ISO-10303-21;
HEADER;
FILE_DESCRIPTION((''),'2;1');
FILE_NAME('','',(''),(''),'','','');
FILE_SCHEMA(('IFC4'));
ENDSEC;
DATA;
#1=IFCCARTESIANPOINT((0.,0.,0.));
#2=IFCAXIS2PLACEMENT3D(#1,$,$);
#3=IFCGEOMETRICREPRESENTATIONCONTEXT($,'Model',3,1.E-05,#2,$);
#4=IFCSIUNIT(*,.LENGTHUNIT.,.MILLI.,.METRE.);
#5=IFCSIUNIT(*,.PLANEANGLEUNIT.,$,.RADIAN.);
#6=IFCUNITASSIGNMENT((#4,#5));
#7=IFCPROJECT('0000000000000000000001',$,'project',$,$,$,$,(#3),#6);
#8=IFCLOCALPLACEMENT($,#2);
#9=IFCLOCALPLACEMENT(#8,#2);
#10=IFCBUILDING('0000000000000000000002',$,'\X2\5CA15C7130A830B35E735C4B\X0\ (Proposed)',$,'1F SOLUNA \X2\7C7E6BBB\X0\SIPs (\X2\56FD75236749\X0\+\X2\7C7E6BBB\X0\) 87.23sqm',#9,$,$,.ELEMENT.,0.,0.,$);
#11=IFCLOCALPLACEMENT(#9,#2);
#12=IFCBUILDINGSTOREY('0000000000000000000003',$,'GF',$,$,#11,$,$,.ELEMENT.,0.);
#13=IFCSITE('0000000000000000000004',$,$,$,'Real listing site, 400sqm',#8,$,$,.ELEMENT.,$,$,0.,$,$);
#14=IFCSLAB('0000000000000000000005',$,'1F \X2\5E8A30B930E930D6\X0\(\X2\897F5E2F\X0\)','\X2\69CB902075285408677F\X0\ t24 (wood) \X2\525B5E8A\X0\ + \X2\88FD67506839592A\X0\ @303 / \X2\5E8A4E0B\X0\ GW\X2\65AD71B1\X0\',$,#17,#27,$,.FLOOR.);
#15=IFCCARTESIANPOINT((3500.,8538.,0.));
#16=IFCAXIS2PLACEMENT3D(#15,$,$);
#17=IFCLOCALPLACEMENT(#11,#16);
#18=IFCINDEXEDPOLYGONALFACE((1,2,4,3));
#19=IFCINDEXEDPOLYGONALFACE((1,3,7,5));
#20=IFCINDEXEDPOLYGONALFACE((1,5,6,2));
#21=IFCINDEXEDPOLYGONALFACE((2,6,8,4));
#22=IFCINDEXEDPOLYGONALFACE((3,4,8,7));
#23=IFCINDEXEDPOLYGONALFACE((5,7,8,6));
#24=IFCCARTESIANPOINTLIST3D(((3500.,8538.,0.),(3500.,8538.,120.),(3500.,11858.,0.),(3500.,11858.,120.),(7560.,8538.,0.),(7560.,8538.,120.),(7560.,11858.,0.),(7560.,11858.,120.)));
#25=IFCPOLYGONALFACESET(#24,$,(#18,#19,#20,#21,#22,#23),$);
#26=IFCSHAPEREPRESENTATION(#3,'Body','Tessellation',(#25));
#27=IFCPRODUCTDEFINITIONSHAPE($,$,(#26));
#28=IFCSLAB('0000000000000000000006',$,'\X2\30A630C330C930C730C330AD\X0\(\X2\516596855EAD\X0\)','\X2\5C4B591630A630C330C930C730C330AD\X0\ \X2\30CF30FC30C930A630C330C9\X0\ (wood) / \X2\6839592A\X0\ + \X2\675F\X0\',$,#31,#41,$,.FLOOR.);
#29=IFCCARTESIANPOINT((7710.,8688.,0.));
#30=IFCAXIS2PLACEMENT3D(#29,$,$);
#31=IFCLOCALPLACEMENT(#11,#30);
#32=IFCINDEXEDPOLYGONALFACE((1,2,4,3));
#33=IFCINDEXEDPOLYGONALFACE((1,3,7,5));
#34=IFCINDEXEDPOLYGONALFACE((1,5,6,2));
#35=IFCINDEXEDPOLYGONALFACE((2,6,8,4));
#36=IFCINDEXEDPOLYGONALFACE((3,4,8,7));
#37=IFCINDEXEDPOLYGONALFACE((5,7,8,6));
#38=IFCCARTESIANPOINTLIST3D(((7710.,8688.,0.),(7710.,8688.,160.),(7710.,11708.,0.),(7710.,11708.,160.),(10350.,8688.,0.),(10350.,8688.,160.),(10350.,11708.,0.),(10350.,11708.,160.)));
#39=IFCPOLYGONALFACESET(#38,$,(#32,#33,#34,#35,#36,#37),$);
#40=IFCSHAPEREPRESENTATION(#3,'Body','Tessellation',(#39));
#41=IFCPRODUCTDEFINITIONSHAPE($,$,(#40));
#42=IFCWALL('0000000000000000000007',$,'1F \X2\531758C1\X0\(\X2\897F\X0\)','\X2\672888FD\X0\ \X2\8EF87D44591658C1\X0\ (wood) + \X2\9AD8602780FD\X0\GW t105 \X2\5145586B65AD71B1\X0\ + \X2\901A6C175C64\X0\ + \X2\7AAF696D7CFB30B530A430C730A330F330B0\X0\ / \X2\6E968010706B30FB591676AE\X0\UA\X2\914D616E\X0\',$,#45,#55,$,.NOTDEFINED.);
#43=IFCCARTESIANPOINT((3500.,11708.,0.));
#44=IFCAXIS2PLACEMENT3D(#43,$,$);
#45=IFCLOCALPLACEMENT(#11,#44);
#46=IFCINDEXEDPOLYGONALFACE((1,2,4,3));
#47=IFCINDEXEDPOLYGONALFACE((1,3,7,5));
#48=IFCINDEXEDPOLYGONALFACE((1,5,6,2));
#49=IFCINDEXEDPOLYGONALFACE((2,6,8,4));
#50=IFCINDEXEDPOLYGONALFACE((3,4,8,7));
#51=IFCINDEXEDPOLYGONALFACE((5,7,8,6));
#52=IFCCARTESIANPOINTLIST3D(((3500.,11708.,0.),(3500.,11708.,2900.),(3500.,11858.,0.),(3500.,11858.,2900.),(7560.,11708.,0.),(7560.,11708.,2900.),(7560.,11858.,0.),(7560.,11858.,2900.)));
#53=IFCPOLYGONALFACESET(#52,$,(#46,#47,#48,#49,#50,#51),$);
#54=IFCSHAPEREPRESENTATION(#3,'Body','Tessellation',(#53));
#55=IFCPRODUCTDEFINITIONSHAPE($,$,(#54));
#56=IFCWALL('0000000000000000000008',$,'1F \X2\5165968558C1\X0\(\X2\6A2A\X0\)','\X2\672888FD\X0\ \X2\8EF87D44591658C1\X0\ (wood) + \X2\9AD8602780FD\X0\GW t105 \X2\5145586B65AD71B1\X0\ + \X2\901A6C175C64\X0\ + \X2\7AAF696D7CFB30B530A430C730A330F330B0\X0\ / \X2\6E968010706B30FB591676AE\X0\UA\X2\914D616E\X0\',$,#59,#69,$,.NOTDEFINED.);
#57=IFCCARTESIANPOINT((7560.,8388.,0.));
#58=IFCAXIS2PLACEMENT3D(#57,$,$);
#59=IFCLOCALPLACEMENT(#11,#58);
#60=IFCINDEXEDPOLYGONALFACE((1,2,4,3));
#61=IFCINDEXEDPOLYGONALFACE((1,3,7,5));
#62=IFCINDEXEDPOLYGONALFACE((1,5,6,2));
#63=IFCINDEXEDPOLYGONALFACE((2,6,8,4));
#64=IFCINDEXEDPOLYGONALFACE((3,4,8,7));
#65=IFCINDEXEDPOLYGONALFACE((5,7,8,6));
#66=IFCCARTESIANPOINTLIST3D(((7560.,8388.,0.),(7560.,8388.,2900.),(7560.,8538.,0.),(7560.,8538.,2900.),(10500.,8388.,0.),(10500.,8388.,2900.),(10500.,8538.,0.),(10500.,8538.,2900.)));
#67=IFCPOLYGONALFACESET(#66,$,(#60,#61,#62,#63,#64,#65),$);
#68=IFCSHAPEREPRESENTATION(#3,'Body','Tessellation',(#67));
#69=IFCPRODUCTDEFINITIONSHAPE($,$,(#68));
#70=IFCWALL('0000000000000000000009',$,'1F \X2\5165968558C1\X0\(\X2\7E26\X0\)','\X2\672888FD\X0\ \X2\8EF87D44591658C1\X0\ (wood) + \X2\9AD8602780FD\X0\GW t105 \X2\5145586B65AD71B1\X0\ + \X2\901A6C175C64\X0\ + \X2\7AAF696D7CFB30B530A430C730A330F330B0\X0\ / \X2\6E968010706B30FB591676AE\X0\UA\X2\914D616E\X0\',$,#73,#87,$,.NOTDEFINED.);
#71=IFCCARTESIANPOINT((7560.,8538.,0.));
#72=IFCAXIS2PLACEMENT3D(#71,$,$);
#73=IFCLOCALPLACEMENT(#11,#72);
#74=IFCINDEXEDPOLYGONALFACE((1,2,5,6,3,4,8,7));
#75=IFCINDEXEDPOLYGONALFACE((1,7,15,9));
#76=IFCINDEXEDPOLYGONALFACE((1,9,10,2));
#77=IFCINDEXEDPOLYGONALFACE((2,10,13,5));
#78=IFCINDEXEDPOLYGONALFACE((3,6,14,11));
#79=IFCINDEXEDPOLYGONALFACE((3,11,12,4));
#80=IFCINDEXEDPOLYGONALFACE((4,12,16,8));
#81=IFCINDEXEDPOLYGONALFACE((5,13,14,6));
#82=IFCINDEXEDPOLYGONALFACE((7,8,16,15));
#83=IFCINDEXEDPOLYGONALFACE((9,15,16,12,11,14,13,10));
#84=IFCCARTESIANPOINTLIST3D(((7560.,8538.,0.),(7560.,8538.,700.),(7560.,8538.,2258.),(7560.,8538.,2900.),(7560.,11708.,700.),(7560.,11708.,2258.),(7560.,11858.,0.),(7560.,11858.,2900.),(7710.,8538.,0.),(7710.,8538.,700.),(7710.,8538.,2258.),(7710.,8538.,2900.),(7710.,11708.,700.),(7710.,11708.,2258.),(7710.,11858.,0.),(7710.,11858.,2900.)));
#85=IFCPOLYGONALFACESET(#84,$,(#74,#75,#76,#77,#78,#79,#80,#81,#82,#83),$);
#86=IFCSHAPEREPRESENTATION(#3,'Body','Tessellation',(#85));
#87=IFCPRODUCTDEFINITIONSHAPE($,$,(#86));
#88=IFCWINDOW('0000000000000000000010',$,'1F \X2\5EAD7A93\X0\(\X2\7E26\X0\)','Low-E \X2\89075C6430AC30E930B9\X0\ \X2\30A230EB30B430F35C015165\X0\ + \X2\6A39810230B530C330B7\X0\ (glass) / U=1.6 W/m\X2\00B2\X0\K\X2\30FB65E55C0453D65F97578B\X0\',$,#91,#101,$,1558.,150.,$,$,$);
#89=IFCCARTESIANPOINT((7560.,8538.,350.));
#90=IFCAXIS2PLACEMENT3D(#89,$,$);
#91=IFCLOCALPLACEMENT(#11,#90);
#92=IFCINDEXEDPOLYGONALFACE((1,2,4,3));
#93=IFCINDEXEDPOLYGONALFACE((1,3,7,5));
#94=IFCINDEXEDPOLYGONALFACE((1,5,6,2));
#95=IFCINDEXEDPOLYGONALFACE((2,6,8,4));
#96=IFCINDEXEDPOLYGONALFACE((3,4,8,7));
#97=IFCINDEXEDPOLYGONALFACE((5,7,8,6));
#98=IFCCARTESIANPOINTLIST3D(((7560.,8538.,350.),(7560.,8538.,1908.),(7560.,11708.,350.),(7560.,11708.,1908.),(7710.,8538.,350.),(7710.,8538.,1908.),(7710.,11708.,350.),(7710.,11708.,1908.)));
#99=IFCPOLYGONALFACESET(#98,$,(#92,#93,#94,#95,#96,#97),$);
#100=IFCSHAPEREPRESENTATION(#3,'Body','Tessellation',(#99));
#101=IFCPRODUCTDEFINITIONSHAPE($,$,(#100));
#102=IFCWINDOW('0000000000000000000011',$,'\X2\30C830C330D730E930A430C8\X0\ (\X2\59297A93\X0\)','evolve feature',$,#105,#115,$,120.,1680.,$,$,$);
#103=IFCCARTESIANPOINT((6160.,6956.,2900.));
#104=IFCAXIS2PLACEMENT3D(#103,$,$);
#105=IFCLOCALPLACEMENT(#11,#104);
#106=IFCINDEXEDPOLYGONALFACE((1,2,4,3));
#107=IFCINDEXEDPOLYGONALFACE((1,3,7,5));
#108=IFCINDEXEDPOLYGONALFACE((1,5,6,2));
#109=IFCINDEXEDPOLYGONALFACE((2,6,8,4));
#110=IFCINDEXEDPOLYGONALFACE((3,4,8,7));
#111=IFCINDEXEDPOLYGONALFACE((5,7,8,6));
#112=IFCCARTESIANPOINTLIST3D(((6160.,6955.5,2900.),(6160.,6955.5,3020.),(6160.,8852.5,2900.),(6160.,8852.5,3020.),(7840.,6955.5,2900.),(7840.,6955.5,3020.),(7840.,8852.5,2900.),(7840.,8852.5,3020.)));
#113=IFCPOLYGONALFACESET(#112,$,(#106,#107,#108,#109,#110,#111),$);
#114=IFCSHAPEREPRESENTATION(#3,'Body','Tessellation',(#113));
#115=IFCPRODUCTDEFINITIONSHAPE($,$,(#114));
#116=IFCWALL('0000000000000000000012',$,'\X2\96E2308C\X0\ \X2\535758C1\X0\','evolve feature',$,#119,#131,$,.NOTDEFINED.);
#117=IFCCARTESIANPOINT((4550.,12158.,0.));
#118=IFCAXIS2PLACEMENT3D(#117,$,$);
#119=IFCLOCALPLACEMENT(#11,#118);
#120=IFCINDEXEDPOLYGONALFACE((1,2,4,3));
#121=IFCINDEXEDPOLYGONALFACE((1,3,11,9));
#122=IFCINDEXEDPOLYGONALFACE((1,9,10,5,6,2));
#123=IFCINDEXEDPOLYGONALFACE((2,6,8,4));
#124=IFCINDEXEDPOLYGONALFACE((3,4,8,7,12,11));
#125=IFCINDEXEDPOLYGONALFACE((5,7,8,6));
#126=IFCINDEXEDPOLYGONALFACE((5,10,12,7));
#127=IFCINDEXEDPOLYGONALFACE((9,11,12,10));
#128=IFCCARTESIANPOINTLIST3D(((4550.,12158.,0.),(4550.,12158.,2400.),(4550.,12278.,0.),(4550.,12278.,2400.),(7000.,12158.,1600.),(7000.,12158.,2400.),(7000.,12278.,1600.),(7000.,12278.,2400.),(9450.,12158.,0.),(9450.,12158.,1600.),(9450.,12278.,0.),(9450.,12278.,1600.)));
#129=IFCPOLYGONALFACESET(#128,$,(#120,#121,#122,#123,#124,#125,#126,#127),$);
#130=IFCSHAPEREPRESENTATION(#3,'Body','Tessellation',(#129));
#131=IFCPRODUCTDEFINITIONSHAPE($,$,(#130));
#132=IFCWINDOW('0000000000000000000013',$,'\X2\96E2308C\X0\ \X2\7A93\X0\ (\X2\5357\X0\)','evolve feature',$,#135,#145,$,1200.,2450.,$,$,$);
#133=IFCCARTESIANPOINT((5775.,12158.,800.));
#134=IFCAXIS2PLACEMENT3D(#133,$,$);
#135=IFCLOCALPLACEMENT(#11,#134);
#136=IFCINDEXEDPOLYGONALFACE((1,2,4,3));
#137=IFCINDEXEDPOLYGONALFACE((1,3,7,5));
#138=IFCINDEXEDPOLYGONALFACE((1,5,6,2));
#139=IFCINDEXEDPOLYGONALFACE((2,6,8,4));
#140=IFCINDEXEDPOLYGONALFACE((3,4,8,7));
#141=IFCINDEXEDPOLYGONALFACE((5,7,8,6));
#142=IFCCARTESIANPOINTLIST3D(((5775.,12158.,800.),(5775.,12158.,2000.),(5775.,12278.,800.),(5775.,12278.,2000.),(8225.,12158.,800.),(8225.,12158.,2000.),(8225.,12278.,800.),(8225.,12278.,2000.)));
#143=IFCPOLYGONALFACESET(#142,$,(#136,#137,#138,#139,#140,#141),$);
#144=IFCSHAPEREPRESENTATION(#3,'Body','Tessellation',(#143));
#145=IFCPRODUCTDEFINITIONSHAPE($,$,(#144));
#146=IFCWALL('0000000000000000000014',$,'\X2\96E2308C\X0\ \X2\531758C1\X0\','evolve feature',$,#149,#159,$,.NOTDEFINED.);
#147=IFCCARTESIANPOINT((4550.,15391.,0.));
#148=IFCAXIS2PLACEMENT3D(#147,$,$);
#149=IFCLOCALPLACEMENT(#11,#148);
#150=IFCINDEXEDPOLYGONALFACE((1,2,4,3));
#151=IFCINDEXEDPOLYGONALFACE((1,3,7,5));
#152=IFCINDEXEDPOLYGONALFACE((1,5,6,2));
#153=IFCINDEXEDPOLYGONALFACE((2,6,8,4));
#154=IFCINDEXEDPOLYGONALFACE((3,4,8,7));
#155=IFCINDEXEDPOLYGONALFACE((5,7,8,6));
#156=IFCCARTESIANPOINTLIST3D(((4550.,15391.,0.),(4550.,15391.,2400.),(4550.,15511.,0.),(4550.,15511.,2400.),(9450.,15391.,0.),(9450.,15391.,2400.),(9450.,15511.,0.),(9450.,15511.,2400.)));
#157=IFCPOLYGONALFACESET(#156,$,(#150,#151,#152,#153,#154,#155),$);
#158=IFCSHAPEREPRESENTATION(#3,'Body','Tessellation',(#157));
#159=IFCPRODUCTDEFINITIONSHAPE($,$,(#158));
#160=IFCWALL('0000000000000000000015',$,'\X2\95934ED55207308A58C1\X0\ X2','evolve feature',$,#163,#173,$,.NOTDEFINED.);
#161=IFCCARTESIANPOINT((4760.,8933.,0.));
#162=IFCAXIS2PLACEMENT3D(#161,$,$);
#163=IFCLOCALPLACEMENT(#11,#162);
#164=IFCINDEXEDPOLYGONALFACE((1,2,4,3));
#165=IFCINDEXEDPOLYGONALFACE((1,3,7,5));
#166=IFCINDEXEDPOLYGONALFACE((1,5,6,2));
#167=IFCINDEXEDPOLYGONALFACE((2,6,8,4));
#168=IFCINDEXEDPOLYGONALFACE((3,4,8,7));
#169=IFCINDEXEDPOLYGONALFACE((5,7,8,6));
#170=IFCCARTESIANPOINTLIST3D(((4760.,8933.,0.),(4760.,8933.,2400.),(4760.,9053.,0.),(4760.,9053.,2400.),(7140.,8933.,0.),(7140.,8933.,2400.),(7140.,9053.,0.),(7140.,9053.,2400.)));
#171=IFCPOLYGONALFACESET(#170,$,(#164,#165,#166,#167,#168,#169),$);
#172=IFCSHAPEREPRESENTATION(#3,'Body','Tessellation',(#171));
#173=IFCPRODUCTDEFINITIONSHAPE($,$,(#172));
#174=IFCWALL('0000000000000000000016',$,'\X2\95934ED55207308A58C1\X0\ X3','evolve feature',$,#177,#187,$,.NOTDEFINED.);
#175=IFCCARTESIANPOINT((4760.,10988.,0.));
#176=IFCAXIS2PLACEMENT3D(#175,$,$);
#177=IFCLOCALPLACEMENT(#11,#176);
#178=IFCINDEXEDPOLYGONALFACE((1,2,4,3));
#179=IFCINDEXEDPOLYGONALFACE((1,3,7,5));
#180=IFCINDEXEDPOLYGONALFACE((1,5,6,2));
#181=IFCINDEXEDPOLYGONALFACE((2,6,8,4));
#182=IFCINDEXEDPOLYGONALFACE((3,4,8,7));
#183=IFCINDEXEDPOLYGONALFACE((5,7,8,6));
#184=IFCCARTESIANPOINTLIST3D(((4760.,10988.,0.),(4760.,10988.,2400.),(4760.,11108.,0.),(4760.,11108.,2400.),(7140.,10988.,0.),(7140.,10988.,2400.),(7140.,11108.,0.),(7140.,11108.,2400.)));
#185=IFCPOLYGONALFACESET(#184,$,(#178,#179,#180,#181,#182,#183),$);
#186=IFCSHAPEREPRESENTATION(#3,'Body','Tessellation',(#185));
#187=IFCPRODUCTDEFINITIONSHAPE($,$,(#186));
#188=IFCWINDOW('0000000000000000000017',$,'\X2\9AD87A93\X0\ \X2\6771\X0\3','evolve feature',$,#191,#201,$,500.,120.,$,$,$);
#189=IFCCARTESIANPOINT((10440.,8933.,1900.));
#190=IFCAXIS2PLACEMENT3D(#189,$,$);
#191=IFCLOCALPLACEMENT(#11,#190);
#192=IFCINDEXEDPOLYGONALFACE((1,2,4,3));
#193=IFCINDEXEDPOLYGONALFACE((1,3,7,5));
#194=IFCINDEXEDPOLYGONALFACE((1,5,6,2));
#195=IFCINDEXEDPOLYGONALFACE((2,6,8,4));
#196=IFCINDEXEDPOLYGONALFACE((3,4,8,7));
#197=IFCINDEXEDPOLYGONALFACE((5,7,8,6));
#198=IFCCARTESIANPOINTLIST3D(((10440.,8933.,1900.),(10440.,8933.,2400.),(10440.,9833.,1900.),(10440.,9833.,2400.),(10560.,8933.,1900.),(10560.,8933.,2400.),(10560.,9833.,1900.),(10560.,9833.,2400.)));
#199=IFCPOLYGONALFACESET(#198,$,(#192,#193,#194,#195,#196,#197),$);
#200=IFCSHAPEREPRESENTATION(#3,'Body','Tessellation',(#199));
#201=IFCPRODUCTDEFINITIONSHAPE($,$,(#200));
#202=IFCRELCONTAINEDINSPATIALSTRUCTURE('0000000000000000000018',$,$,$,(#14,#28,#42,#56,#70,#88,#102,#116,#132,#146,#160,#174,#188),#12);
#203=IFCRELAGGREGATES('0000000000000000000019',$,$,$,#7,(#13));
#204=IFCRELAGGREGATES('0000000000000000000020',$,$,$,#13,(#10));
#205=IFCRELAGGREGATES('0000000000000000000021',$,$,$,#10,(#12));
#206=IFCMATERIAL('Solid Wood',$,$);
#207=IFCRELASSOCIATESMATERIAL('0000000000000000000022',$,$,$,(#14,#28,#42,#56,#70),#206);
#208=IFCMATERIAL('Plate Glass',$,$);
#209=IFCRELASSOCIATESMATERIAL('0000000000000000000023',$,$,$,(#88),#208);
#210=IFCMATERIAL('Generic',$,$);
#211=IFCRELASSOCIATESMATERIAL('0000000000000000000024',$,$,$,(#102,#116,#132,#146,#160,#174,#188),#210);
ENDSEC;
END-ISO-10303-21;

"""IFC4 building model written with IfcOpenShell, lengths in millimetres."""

from ifc_helpers import new_model, si_unit, frame, frame_2d, origin, place, context, project, spatial, rectangle, extrude, material, element, fill, save


model = new_model("IFC4")

# Units and contexts
model_context = context("Model", 3, precision=1e-05, world=origin())
ifc_project = project(units=[si_unit("LENGTHUNIT", "METRE", prefix="MILLI"), si_unit("PLANEANGLEUNIT", "RADIAN")], contexts=[model_context])

# Site, building, storey
site_placement = place(None, origin())
site = spatial("IfcSite", under=ifc_project, at=site_placement, ObjectType="Real listing site, 400sqm", CompositionType="ELEMENT", RefElevation=0.0)
building_placement = place(site_placement, origin())
building = spatial("IfcBuilding", under=site, at=building_placement, Name="岡山エコ平屋 (Proposed)", ObjectType="1F SOLUNA 籾殻SIPs (国産杉+籾殻) 87.23sqm", CompositionType="ELEMENT", ElevationOfRefHeight=0.0, ElevationOfTerrain=0.0)
storey_placement = place(building_placement, origin())
storey = spatial("IfcBuildingStorey", under=building, at=storey_placement, Name="GF", CompositionType="ELEMENT", Elevation=0.0)

# Slabs
ifc_material_1 = material(Name="Solid Wood")
slab_1_placement = place(storey_placement, frame((3500.0, 8538.0, 0.0)))
element("IfcSlab", 1, at=slab_1_placement, inside=storey, material=ifc_material_1, Name="1F 床スラブ(西帯)", Description="構造用合板 t24 (wood) 剛床 + 製材根太 @303 / 床下 GW断熱", PredefinedType="FLOOR", context=model_context, shape_type="SweptSolid", body=[
    extrude(rectangle(XDim=4060.0, YDim=3320.0, at=frame_2d((2030.0, 1660.0))), frame((3500.0, 8538.0, 0.0)), (0.0, 0.0, 1.0), 120.0),
])
slab_2_placement = place(storey_placement, frame((7710.0, 8688.0, 0.0)))
element("IfcSlab", 2, at=slab_2_placement, inside=storey, material=ifc_material_1, Name="ウッドデッキ(入隅庭)", Description="屋外ウッドデッキ ハードウッド (wood) / 根太 + 束", PredefinedType="FLOOR", context=model_context, shape_type="SweptSolid", body=[
    extrude(rectangle(XDim=2640.0, YDim=3020.0, at=frame_2d((1320.0, 1510.0))), frame((7710.0, 8688.0, 0.0)), (0.0, 0.0, 1.0), 160.0),
])
ifc_material_2 = material(Name="Generic")

# Walls
wall_1_placement = place(storey_placement, frame((3500.0, 11708.0, 0.0)))
element("IfcWall", 3, at=wall_1_placement, inside=storey, material=ifc_material_1, Name="1F 北壁(西)", Description="木製 軸組外壁 (wood) + 高性能GW t105 充填断熱 + 通気層 + 窯業系サイディング / 準耐火・外皮UA配慮", PredefinedType="NOTDEFINED", context=model_context, shape_type="SweptSolid", body=[
    extrude(rectangle(XDim=4060.0, YDim=150.0, at=frame_2d((2030.0, 75.0))), frame((3500.0, 11708.0, 0.0)), (0.0, 0.0, 1.0), 2900.0),
])
wall_2_placement = place(storey_placement, frame((7560.0, 8388.0, 0.0)))
element("IfcWall", 4, at=wall_2_placement, inside=storey, material=ifc_material_1, Name="1F 入隅壁(横)", Description="木製 軸組外壁 (wood) + 高性能GW t105 充填断熱 + 通気層 + 窯業系サイディング / 準耐火・外皮UA配慮", PredefinedType="NOTDEFINED", context=model_context, shape_type="SweptSolid", body=[
    extrude(rectangle(XDim=2940.0, YDim=150.0, at=frame_2d((1470.0, 75.0))), frame((7560.0, 8388.0, 0.0)), (0.0, 0.0, 1.0), 2900.0),
])

# Wall, opening, window
wall_3_placement = place(storey_placement, frame((7560.0, 8538.0, 0.0)))
wall_3 = element("IfcWall", 5, at=wall_3_placement, inside=storey, material=ifc_material_1, Name="1F 入隅壁(縦)", Description="木製 軸組外壁 (wood) + 高性能GW t105 充填断熱 + 通気層 + 窯業系サイディング / 準耐火・外皮UA配慮", PredefinedType="NOTDEFINED", context=model_context, shape_type="SweptSolid", body=[
    extrude(rectangle(XDim=150.0, YDim=3320.0, at=frame_2d((75.0, 1660.0))), frame((7560.0, 8538.0, 0.0)), (0.0, 0.0, 1.0), 2900.0),
])
opening_1_placement = place(storey_placement, frame((7560.0, 8538.0, 350.0)))
opening_1 = element("IfcOpeningElement", 6, at=opening_1_placement, cuts=wall_3, PredefinedType="NOTDEFINED", context=model_context, shape_type="SweptSolid", body=[
    extrude(rectangle(XDim=150.0, YDim=3170.0, at=frame_2d((75.0, 1585.0))), frame((7560.0, 8538.0, 350.0)), (0.0, 0.0, 1.0), 1558.0),
])
ifc_material_3 = material(Name="Plate Glass")
window_1_placement = place(storey_placement, frame((7560.0, 8538.0, 350.0)))
window_1 = element("IfcWindow", 7, at=window_1_placement, inside=storey, material=ifc_material_3, Name="1F 庭窓(縦)", Description="Low-E 複層ガラス アルゴン封入 + 樹脂サッシ (glass) / U=1.6 W/m²K・日射取得型", OverallHeight=1558.0, OverallWidth=150.0, context=model_context, shape_type="SweptSolid", body=[
    extrude(rectangle(XDim=150.0, YDim=3170.0, at=frame_2d((75.0, 1585.0))), frame((7560.0, 8538.0, 350.0)), (0.0, 0.0, 1.0), 1558.0),
])
fill(opening_1, window_1)

# Window
window_2_placement = place(storey_placement, frame((6160.0, 6956.0, 2900.0)))
element("IfcWindow", 8, at=window_2_placement, inside=storey, material=ifc_material_2, Name="トップライト (天窓)", Description="evolve feature", OverallHeight=120.0, OverallWidth=1680.0, context=model_context, shape_type="SweptSolid", body=[
    extrude(rectangle(XDim=1680.0, YDim=1897.0, at=frame_2d((840.0, 948.0))), frame((6160.0, 6956.0, 2900.0)), (0.0, 0.0, 1.0), 120.0),
])

# Wall, opening, window
wall_4_placement = place(storey_placement, frame((4550.0, 12158.0, 0.0)))
wall_4 = element("IfcWall", 9, at=wall_4_placement, inside=storey, material=ifc_material_2, Name="離れ 南壁", Description="evolve feature", PredefinedType="NOTDEFINED", context=model_context, shape_type="SweptSolid", body=[
    extrude(rectangle(XDim=4900.0, YDim=120.0, at=frame_2d((2450.0, 60.0))), frame((4550.0, 12158.0, 0.0)), (0.0, 0.0, 1.0), 2400.0),
])
opening_2_placement = place(storey_placement, frame((5775.0, 12158.0, 800.0)))
opening_2 = element("IfcOpeningElement", 10, at=opening_2_placement, cuts=wall_4, PredefinedType="NOTDEFINED", context=model_context, shape_type="SweptSolid", body=[
    extrude(rectangle(XDim=2450.0, YDim=120.0, at=frame_2d((1225.0, 60.0))), frame((5775.0, 12158.0, 800.0)), (0.0, 0.0, 1.0), 1200.0),
])
window_3_placement = place(storey_placement, frame((5775.0, 12158.0, 800.0)))
window_3 = element("IfcWindow", 11, at=window_3_placement, inside=storey, material=ifc_material_2, Name="離れ 窓 (南)", Description="evolve feature", OverallHeight=1200.0, OverallWidth=2450.0, context=model_context, shape_type="SweptSolid", body=[
    extrude(rectangle(XDim=2450.0, YDim=120.0, at=frame_2d((1225.0, 60.0))), frame((5775.0, 12158.0, 800.0)), (0.0, 0.0, 1.0), 1200.0),
])
fill(opening_2, window_3)

# Walls
wall_5_placement = place(storey_placement, frame((4550.0, 15391.0, 0.0)))
element("IfcWall", 12, at=wall_5_placement, inside=storey, material=ifc_material_2, Name="離れ 北壁", Description="evolve feature", PredefinedType="NOTDEFINED", context=model_context, shape_type="SweptSolid", body=[
    extrude(rectangle(XDim=4900.0, YDim=120.0, at=frame_2d((2450.0, 60.0))), frame((4550.0, 15391.0, 0.0)), (0.0, 0.0, 1.0), 2400.0),
])
wall_6_placement = place(storey_placement, frame((4760.0, 8933.0, 0.0)))
element("IfcWall", 13, at=wall_6_placement, inside=storey, material=ifc_material_2, Name="間仕切り壁 X2", Description="evolve feature", PredefinedType="NOTDEFINED", context=model_context, shape_type="SweptSolid", body=[
    extrude(rectangle(XDim=2380.0, YDim=120.0, at=frame_2d((1190.0, 60.0))), frame((4760.0, 8933.0, 0.0)), (0.0, 0.0, 1.0), 2400.0),
])
wall_7_placement = place(storey_placement, frame((4760.0, 10988.0, 0.0)))
element("IfcWall", 14, at=wall_7_placement, inside=storey, material=ifc_material_2, Name="間仕切り壁 X3", Description="evolve feature", PredefinedType="NOTDEFINED", context=model_context, shape_type="SweptSolid", body=[
    extrude(rectangle(XDim=2380.0, YDim=120.0, at=frame_2d((1190.0, 60.0))), frame((4760.0, 10988.0, 0.0)), (0.0, 0.0, 1.0), 2400.0),
])

# Window
window_4_placement = place(storey_placement, frame((10440.0, 8933.0, 1900.0)))
element("IfcWindow", 15, at=window_4_placement, inside=storey, material=ifc_material_2, Name="高窓 東3", Description="evolve feature", OverallHeight=500.0, OverallWidth=120.0, context=model_context, shape_type="SweptSolid", body=[
    extrude(rectangle(XDim=120.0, YDim=900.0, at=frame_2d((60.0, 450.0))), frame((10440.0, 8933.0, 1900.0)), (0.0, 0.0, 1.0), 500.0),
])

save(model, "model.ifc")
